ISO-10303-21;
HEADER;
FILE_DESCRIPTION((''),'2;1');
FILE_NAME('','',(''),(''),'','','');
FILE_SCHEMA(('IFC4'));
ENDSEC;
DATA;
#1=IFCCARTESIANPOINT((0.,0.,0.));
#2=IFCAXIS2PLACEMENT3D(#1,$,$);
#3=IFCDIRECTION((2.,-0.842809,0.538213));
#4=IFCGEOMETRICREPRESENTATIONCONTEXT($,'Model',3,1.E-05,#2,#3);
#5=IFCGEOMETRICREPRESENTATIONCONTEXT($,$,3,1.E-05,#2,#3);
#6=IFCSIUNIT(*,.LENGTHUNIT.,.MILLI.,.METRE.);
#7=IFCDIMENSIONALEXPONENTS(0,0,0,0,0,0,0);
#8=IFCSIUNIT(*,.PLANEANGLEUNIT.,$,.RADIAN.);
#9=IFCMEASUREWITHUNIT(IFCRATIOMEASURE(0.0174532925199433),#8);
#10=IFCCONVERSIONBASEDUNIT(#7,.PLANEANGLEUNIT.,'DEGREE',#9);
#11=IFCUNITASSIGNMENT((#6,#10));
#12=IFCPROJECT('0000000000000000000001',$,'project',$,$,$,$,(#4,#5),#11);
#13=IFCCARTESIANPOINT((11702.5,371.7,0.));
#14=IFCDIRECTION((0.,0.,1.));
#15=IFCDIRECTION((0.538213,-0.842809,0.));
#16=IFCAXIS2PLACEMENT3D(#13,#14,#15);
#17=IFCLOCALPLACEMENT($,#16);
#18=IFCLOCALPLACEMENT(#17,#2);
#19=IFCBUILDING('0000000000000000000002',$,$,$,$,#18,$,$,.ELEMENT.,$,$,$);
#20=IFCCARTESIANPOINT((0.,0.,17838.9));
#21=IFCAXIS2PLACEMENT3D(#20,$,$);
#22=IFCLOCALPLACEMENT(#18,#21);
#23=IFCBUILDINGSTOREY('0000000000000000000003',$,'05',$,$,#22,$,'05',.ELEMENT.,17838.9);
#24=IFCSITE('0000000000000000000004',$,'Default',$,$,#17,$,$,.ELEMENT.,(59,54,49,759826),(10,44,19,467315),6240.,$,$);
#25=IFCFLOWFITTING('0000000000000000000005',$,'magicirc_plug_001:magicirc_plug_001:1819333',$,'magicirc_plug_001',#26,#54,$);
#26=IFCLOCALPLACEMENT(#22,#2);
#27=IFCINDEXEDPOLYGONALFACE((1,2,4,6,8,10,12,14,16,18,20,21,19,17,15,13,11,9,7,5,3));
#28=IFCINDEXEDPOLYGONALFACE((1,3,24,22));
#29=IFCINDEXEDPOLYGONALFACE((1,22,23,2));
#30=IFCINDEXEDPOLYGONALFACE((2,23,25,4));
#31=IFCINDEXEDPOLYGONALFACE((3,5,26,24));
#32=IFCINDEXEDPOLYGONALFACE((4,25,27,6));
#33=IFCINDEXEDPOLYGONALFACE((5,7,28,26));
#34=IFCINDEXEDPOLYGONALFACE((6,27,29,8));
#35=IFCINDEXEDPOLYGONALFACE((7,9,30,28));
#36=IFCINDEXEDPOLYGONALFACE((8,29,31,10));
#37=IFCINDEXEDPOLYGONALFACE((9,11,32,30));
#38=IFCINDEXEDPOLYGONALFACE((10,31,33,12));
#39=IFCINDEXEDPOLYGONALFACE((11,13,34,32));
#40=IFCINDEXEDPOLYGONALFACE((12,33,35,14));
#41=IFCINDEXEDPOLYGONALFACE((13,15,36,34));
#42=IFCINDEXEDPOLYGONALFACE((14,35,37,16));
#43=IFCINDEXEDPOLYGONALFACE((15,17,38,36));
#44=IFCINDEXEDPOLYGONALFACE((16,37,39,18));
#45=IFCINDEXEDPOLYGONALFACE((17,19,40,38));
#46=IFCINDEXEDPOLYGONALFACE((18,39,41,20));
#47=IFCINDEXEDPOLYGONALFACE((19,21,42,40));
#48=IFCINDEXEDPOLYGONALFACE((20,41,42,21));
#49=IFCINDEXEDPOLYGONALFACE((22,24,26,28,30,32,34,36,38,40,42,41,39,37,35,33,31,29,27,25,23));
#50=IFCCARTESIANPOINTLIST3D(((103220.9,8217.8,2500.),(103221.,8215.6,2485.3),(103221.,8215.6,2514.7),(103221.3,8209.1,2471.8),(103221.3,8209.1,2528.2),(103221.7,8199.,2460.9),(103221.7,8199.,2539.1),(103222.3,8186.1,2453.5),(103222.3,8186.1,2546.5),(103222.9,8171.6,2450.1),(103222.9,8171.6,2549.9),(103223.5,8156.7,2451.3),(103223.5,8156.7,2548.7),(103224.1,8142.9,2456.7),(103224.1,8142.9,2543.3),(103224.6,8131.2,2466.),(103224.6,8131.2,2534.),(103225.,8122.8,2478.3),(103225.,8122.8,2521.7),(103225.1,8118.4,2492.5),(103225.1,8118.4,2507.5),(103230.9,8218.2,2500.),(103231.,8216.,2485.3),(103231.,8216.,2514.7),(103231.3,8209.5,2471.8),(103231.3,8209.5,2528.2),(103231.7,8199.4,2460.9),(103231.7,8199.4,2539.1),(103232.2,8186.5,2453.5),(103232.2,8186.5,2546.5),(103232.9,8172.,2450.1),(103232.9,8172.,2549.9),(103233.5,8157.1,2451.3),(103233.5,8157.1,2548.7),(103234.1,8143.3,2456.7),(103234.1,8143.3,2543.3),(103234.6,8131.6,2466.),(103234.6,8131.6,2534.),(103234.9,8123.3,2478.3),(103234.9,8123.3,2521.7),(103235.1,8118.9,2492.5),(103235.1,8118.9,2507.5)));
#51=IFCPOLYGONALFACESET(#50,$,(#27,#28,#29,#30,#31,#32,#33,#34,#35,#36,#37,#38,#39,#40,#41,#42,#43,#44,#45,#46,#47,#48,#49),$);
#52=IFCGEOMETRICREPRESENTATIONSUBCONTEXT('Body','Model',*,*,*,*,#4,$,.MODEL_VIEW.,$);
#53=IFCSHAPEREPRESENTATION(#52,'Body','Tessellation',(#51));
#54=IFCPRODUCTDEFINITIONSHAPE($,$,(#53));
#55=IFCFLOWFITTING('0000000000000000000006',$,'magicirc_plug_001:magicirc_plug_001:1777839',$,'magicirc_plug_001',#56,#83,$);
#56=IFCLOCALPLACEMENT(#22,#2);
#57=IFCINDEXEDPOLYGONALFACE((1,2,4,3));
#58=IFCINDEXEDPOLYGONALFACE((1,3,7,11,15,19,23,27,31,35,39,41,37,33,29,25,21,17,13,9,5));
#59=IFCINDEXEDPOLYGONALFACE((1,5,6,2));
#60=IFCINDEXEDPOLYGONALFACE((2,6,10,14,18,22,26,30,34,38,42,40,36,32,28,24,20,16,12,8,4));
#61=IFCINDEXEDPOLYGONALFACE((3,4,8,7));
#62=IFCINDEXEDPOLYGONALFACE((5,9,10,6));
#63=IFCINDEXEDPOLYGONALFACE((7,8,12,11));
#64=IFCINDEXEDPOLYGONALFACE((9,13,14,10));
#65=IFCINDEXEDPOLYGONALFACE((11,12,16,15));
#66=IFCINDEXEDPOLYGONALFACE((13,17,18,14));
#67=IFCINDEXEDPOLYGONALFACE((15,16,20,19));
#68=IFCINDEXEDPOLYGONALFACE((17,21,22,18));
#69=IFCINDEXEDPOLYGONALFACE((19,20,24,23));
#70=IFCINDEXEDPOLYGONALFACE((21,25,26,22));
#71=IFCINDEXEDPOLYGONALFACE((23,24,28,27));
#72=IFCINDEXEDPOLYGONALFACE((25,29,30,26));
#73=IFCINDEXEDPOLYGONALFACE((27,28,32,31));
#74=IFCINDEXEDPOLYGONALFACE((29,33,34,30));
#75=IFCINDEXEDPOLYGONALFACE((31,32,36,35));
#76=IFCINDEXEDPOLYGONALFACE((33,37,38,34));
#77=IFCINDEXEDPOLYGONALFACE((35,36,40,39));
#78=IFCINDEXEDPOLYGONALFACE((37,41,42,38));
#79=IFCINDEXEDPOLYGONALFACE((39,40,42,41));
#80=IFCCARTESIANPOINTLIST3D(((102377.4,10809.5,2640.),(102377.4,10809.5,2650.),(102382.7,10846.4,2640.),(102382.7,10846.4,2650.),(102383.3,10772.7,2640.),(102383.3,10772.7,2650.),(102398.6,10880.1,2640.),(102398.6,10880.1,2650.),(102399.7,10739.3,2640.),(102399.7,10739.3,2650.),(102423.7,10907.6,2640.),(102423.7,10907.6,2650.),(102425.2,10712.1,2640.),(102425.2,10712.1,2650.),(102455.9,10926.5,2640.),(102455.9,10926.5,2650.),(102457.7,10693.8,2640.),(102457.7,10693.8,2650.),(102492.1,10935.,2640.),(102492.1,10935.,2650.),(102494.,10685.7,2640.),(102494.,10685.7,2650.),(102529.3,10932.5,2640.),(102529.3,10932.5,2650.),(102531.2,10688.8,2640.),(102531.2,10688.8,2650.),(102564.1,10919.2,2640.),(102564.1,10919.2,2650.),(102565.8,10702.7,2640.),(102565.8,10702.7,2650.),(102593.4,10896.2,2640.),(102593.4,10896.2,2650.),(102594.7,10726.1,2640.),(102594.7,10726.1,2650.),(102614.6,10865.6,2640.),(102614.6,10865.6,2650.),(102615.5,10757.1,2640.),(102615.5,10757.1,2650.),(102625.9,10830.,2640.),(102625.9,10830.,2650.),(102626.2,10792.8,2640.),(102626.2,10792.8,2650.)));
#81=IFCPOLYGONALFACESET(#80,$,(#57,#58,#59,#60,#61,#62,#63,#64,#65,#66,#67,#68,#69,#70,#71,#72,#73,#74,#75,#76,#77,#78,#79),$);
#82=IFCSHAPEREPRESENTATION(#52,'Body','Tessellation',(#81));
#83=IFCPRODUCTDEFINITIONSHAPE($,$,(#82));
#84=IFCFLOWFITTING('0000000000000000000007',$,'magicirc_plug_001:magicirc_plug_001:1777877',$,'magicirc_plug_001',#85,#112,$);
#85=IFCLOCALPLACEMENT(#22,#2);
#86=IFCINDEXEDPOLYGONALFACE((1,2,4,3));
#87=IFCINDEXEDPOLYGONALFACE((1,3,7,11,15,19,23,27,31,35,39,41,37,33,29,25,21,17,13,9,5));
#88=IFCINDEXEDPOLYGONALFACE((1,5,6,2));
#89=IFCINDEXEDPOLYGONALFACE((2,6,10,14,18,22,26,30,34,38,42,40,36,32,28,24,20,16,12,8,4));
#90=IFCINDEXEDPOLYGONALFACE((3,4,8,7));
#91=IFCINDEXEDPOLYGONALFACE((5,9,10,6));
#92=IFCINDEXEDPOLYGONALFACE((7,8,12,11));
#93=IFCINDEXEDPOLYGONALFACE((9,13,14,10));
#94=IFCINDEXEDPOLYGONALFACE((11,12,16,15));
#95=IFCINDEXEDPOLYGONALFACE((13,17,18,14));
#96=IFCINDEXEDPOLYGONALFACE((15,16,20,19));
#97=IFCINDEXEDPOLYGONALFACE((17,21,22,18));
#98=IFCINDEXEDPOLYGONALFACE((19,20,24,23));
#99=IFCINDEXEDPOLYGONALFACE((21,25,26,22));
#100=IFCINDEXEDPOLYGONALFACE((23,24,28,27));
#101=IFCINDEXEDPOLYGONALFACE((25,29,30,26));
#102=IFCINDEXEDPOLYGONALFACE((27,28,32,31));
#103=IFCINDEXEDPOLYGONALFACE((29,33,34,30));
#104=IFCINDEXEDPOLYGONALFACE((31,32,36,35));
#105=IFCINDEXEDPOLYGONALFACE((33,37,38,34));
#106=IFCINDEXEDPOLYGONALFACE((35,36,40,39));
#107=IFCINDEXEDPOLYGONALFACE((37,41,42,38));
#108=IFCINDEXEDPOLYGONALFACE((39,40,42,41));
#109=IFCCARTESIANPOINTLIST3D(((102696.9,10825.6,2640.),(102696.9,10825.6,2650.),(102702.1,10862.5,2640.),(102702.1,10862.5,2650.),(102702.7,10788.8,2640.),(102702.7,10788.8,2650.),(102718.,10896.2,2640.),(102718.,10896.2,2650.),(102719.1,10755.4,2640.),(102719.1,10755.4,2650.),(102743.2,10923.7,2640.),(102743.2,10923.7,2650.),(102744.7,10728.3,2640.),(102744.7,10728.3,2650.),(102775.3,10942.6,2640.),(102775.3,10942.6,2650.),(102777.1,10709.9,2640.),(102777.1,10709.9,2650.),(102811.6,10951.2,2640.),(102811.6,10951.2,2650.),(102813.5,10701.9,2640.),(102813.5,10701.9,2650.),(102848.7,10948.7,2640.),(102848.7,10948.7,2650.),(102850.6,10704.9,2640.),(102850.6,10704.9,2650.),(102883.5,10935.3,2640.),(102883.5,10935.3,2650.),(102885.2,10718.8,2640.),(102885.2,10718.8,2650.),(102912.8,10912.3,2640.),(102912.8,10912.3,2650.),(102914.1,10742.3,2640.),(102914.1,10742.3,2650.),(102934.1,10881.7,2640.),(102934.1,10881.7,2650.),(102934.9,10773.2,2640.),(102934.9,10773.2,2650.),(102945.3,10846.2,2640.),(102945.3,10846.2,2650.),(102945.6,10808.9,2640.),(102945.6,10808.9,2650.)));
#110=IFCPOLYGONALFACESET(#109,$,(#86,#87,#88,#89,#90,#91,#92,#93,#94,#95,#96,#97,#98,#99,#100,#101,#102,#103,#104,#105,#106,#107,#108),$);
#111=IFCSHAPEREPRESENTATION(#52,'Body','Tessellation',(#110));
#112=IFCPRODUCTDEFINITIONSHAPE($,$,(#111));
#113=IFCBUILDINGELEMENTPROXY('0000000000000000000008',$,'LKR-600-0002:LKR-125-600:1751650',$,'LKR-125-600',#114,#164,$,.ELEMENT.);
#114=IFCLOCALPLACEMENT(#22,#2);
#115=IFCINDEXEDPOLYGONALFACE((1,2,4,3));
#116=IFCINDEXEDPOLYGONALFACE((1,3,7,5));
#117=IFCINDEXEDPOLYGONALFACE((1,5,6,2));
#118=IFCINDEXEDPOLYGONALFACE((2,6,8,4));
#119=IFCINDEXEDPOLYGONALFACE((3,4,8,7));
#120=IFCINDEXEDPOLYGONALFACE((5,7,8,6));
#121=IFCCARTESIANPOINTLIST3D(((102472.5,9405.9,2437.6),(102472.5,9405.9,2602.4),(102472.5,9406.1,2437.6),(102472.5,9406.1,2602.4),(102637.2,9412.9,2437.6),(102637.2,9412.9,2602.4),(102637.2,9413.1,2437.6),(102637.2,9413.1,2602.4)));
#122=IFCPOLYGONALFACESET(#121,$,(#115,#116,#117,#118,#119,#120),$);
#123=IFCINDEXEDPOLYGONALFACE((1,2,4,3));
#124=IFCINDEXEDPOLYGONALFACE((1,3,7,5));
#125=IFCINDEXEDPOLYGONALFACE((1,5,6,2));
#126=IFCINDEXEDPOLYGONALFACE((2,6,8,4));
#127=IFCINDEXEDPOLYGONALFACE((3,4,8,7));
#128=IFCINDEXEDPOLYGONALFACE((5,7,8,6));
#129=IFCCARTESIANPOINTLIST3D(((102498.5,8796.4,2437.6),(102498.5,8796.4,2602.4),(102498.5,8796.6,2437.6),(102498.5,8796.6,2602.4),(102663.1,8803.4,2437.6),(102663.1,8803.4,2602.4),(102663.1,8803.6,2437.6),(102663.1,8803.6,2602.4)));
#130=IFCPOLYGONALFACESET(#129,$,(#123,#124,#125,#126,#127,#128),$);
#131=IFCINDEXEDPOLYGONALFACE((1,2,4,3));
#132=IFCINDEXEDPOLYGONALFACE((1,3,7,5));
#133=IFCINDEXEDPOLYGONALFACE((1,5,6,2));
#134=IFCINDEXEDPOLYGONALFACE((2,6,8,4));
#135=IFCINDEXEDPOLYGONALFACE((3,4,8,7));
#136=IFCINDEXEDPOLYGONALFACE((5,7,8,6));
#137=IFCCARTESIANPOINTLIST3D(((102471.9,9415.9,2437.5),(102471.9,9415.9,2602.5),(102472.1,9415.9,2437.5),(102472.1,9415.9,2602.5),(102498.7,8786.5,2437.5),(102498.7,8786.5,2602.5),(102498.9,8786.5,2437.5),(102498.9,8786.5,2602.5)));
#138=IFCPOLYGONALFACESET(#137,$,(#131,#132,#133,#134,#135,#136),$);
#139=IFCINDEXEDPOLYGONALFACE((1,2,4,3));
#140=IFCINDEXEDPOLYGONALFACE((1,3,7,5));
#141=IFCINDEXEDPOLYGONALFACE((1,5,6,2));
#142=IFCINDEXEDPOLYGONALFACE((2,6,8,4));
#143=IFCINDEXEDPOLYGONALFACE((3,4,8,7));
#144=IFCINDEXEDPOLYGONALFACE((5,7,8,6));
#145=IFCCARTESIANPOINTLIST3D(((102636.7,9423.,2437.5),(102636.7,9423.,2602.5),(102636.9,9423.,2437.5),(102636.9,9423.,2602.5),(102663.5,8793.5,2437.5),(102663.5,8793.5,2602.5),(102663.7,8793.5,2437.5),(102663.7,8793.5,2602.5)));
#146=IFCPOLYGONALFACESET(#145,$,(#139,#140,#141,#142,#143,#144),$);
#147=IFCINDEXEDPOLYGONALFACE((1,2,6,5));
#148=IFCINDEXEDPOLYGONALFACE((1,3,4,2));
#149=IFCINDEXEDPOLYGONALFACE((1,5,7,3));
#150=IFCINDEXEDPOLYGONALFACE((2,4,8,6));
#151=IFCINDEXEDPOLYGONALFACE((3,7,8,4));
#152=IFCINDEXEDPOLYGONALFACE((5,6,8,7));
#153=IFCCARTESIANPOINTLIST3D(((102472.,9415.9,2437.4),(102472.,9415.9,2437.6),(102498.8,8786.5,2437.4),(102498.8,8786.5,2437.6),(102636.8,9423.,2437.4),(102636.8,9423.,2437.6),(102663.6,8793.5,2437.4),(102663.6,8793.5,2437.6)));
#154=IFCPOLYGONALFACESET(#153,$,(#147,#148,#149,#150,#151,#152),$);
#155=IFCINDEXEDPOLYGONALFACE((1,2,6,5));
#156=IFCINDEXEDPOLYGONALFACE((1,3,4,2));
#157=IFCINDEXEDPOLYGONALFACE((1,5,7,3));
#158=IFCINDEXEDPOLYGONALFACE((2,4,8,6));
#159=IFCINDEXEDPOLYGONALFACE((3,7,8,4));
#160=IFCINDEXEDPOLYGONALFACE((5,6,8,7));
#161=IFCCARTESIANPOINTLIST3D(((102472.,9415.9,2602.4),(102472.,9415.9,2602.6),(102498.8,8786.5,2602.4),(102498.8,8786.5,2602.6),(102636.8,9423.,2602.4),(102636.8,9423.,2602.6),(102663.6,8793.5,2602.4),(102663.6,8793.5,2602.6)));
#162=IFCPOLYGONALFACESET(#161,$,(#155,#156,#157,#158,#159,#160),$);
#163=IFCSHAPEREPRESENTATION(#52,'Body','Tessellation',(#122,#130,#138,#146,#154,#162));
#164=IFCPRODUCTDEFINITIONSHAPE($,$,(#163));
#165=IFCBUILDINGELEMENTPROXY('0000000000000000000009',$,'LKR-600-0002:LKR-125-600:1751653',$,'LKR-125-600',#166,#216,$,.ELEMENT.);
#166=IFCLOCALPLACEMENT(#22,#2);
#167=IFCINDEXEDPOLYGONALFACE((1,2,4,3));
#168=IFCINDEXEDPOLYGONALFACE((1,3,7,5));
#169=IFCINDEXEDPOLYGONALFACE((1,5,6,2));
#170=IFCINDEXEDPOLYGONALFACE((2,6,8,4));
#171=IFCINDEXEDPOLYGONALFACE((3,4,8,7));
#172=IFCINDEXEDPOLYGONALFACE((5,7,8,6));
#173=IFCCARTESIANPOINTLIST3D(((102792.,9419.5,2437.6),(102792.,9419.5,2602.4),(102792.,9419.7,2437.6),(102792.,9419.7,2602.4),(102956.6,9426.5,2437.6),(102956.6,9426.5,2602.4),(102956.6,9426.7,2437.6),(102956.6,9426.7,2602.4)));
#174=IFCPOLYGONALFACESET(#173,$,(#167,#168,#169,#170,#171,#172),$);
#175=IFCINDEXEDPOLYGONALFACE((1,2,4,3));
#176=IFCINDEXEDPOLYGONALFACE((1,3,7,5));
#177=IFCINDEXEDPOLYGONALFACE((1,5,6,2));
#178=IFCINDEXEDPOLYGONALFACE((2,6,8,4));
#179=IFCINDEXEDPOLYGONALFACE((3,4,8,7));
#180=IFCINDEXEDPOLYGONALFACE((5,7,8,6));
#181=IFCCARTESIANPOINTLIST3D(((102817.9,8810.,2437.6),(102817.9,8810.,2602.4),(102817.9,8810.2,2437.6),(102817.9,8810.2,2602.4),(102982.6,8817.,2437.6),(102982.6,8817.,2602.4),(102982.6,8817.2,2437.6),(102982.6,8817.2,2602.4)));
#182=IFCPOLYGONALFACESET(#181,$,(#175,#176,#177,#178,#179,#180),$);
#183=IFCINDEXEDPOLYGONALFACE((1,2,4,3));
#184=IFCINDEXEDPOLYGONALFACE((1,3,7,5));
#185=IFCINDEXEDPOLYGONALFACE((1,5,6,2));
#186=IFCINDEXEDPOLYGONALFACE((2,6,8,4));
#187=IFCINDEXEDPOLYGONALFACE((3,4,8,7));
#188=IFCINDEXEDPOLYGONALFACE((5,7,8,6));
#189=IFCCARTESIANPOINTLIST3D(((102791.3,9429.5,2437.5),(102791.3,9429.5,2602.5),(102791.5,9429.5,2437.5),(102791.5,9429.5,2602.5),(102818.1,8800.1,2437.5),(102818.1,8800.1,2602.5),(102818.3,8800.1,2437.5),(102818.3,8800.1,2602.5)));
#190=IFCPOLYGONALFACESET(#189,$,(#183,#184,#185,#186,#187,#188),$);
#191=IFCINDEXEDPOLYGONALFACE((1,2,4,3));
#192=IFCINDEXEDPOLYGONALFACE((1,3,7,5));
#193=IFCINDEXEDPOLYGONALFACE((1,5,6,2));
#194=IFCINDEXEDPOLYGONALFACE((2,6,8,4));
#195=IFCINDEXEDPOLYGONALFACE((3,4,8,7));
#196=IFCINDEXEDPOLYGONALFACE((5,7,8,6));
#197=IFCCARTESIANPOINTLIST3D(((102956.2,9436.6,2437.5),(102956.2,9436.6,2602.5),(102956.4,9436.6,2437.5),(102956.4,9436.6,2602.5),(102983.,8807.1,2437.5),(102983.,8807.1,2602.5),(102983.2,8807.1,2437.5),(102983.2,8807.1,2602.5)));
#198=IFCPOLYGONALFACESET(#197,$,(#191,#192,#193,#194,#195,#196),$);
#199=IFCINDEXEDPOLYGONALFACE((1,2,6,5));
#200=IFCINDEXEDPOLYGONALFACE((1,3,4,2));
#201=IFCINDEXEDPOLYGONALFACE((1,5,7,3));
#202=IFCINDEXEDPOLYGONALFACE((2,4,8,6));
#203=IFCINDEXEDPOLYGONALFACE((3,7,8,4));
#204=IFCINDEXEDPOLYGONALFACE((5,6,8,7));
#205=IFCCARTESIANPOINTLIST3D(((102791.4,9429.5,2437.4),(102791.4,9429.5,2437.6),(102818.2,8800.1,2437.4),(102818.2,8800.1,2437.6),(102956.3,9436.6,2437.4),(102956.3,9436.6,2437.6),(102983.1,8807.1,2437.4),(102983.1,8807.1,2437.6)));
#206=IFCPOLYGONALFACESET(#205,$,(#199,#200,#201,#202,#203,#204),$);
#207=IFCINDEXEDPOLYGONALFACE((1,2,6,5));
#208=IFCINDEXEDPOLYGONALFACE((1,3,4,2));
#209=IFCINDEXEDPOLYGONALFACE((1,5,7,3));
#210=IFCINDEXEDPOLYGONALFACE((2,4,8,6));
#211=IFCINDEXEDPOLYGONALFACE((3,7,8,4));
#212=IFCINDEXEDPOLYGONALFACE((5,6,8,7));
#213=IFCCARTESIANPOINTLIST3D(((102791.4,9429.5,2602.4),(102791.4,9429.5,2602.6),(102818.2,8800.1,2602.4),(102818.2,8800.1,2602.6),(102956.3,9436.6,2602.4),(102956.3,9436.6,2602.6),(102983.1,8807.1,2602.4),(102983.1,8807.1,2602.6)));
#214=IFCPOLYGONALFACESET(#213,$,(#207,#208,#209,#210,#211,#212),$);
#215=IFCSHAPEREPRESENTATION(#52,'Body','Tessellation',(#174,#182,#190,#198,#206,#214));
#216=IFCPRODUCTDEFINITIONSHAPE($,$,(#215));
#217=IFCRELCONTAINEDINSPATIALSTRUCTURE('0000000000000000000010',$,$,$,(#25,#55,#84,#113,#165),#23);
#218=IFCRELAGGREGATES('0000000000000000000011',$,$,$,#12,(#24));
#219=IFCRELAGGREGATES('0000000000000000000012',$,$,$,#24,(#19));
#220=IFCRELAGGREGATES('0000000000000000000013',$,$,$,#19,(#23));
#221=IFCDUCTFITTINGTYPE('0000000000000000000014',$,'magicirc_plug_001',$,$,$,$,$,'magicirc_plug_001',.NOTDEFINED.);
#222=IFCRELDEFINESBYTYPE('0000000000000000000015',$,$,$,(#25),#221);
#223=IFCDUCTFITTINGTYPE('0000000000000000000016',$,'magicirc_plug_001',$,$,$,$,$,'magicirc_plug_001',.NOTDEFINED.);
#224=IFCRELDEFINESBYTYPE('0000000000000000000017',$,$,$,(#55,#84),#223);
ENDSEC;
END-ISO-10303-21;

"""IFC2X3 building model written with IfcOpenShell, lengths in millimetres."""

from ifc_helpers import new_model, entity, si_unit, converted_unit, direction, frame, frame_2d, origin, place, context, subcontext, project, spatial, rectangle, circle, extrude, source, transform, mapped, type_object, type_shapes, element, save


model = new_model("IFC2X3")

# Units and contexts
model_context = context("Model", 3, precision=1e-05, world=origin(), true_north=direction((2.0, -0.842809, 0.538213)))
context_of_model = context(None, 3, precision=1e-05, world=origin(), true_north=direction((2.0, -0.842809, 0.538213)))
body_context = subcontext(model_context, "Body", "Model", "MODEL_VIEW")
ifc_project = project(units=[si_unit("LENGTHUNIT", "METRE", prefix="MILLI"), converted_unit("PLANEANGLEUNIT", "DEGREE", entity("IfcRatioMeasure", 0.0174532925199433), si_unit("PLANEANGLEUNIT", "RADIAN"), dimensions=[0, 0, 0, 0, 0, 0, 0])], contexts=[model_context, context_of_model])

# Site, building, storey
site_placement = place(None, frame((11702.5, 371.7, 0.0), z_axis=(0.0, 0.0, 1.0), x_axis=(0.538213, -0.842809, 0.0)))
site = spatial("IfcSite", under=ifc_project, at=site_placement, Name="Default", CompositionType="ELEMENT", RefLatitude=(59, 54, 49, 759826), RefLongitude=(10, 44, 19, 467315), RefElevation=6240.0)
building_placement = place(site_placement, origin())
building = spatial("IfcBuilding", under=site, at=building_placement, CompositionType="ELEMENT")
storey_placement = place(building_placement, frame((0.0, 0.0, 17838.9)))
storey = spatial("IfcBuildingStorey", under=building, at=storey_placement, Name="05", LongName="05", CompositionType="ELEMENT", Elevation=17838.9)

# Flow fittings
duct_fitting_type_1 = type_object("IfcDuctFittingType", Name="magicirc_plug_001", ElementType="magicirc_plug_001", PredefinedType="NOTDEFINED")
shared_shape_1 = source(origin(), body_context, "Body", "SweptSolid", [
    extrude(circle(Radius=50.0, at=frame_2d((0.0, 0.0), x_axis=(1.0, 0.0))), frame((0.0, 0.0, 0.0), z_axis=(1.0, 0.0, 0.0), x_axis=(0.0, 1.0, 0.0)), (0.0, 0.0, 1.0), 10.0),
])
type_shapes(duct_fitting_type_1, [shared_shape_1])
flow_fitting_1_placement = place(storey_placement, frame((103223.0, 8167.8, 2500.0), z_axis=(0.0, 0.0, 1.0), x_axis=(0.999095, 0.042537, 0.0)))
element("IfcFlowFitting", 1, at=flow_fitting_1_placement, inside=storey, type_object=duct_fitting_type_1, Name="magicirc_plug_001:magicirc_plug_001:1819333", ObjectType="magicirc_plug_001", context=body_context, shape_type="MappedRepresentation", body=[
    mapped(shared_shape_1, transform((0.0, 0.0, 0.0), scale=1.0)),
])
duct_fitting_type_2 = type_object("IfcDuctFittingType", Name="magicirc_plug_001", ElementType="magicirc_plug_001", PredefinedType="NOTDEFINED")
shared_shape_2 = source(origin(), body_context, "Body", "SweptSolid", [
    extrude(circle(Radius=125.0, at=frame_2d((0.0, 0.0), x_axis=(1.0, 0.0))), frame((0.0, 0.0, 0.0), z_axis=(1.0, 0.0, 0.0), x_axis=(0.0, 1.0, 0.0)), (0.0, 0.0, 1.0), 10.0),
])
type_shapes(duct_fitting_type_2, [shared_shape_2])
for number, where, z_axis, x_axis, name in (
    (2, (102502.4, 10810.5, 2640.0), (0.007643, -0.999971, 0.0), (0.0, 0.0, 1.0), "magicirc_plug_001:magicirc_plug_001:1777839"),
    (3, (102821.9, 10826.6, 2640.0), (0.007643, -0.999971, 0.0), (0.0, 0.0, 1.0), "magicirc_plug_001:magicirc_plug_001:1777877"),
):
    element("IfcFlowFitting", number, at=place(storey_placement, frame(where, z_axis=z_axis, x_axis=x_axis)), inside=storey, type_object=duct_fitting_type_2, Name=name, ObjectType="magicirc_plug_001", context=body_context, shape_type="MappedRepresentation", body=[
        mapped(shared_shape_2, transform((0.0, 0.0, 0.0), scale=1.0)),
    ])

# Building element proxies
shared_shape_3 = source(origin(), body_context, "Body", "SweptSolid", [
    extrude(rectangle(XDim=0.2, YDim=164.8, at=frame_2d((0.0, 0.0), x_axis=(1.0, 0.0))), frame((305.0, 0.0, -82.4)), (0.0, 0.0, 1.0), 164.8),
    extrude(rectangle(XDim=0.2, YDim=164.8, at=frame_2d((0.0, 0.0), x_axis=(1.0, 0.0))), frame((-305.0, 0.0, -82.4)), (0.0, 0.0, 1.0), 164.8),
    extrude(rectangle(XDim=0.2, YDim=630.0, at=frame_2d((0.0, 0.0), x_axis=(1.0, 0.0))), frame((0.0, 82.5, -82.5), z_axis=(0.0, 0.0, 1.0), x_axis=(0.0, 1.0, 0.0)), (0.0, 0.0, 1.0), 165.0),
    extrude(rectangle(XDim=0.2, YDim=630.0, at=frame_2d((0.0, 0.0), x_axis=(1.0, 0.0))), frame((0.0, -82.5, -82.5), z_axis=(0.0, 0.0, 1.0), x_axis=(0.0, 1.0, 0.0)), (0.0, 0.0, 1.0), 165.0),
    extrude(rectangle(XDim=165.0, YDim=630.0, at=frame_2d((0.0, 0.0), x_axis=(1.0, 0.0))), frame((0.0, 0.0, -82.6), z_axis=(0.0, 0.0, 1.0), x_axis=(0.0, -1.0, 0.0)), (0.0, 0.0, 1.0), 0.2),
    extrude(rectangle(XDim=165.0, YDim=630.0, at=frame_2d((0.0, 0.0), x_axis=(1.0, 0.0))), frame((0.0, 0.0, 82.4), z_axis=(0.0, 0.0, 1.0), x_axis=(0.0, -1.0, 0.0)), (0.0, 0.0, 1.0), 0.2),
])
for number, where, z_axis, x_axis, name in (
    (4, (102567.8, 9104.7, 2520.0), (0.0, 0.0, 1.0), (-0.042537, 0.999095, 0.0), "LKR-600-0002:LKR-125-600:1751650"),
    (5, (102887.3, 9118.3, 2520.0), (0.0, 0.0, 1.0), (-0.042537, 0.999095, 0.0), "LKR-600-0002:LKR-125-600:1751653"),
):
    element("IfcBuildingElementProxy", number, at=place(storey_placement, frame(where, z_axis=z_axis, x_axis=x_axis)), inside=storey, Name=name, ObjectType="LKR-125-600", CompositionType="ELEMENT", context=body_context, shape_type="MappedRepresentation", body=[
        mapped(shared_shape_3, transform((0.0, 0.0, 0.0), scale=1.0)),
    ])

save(model, "model.ifc")
